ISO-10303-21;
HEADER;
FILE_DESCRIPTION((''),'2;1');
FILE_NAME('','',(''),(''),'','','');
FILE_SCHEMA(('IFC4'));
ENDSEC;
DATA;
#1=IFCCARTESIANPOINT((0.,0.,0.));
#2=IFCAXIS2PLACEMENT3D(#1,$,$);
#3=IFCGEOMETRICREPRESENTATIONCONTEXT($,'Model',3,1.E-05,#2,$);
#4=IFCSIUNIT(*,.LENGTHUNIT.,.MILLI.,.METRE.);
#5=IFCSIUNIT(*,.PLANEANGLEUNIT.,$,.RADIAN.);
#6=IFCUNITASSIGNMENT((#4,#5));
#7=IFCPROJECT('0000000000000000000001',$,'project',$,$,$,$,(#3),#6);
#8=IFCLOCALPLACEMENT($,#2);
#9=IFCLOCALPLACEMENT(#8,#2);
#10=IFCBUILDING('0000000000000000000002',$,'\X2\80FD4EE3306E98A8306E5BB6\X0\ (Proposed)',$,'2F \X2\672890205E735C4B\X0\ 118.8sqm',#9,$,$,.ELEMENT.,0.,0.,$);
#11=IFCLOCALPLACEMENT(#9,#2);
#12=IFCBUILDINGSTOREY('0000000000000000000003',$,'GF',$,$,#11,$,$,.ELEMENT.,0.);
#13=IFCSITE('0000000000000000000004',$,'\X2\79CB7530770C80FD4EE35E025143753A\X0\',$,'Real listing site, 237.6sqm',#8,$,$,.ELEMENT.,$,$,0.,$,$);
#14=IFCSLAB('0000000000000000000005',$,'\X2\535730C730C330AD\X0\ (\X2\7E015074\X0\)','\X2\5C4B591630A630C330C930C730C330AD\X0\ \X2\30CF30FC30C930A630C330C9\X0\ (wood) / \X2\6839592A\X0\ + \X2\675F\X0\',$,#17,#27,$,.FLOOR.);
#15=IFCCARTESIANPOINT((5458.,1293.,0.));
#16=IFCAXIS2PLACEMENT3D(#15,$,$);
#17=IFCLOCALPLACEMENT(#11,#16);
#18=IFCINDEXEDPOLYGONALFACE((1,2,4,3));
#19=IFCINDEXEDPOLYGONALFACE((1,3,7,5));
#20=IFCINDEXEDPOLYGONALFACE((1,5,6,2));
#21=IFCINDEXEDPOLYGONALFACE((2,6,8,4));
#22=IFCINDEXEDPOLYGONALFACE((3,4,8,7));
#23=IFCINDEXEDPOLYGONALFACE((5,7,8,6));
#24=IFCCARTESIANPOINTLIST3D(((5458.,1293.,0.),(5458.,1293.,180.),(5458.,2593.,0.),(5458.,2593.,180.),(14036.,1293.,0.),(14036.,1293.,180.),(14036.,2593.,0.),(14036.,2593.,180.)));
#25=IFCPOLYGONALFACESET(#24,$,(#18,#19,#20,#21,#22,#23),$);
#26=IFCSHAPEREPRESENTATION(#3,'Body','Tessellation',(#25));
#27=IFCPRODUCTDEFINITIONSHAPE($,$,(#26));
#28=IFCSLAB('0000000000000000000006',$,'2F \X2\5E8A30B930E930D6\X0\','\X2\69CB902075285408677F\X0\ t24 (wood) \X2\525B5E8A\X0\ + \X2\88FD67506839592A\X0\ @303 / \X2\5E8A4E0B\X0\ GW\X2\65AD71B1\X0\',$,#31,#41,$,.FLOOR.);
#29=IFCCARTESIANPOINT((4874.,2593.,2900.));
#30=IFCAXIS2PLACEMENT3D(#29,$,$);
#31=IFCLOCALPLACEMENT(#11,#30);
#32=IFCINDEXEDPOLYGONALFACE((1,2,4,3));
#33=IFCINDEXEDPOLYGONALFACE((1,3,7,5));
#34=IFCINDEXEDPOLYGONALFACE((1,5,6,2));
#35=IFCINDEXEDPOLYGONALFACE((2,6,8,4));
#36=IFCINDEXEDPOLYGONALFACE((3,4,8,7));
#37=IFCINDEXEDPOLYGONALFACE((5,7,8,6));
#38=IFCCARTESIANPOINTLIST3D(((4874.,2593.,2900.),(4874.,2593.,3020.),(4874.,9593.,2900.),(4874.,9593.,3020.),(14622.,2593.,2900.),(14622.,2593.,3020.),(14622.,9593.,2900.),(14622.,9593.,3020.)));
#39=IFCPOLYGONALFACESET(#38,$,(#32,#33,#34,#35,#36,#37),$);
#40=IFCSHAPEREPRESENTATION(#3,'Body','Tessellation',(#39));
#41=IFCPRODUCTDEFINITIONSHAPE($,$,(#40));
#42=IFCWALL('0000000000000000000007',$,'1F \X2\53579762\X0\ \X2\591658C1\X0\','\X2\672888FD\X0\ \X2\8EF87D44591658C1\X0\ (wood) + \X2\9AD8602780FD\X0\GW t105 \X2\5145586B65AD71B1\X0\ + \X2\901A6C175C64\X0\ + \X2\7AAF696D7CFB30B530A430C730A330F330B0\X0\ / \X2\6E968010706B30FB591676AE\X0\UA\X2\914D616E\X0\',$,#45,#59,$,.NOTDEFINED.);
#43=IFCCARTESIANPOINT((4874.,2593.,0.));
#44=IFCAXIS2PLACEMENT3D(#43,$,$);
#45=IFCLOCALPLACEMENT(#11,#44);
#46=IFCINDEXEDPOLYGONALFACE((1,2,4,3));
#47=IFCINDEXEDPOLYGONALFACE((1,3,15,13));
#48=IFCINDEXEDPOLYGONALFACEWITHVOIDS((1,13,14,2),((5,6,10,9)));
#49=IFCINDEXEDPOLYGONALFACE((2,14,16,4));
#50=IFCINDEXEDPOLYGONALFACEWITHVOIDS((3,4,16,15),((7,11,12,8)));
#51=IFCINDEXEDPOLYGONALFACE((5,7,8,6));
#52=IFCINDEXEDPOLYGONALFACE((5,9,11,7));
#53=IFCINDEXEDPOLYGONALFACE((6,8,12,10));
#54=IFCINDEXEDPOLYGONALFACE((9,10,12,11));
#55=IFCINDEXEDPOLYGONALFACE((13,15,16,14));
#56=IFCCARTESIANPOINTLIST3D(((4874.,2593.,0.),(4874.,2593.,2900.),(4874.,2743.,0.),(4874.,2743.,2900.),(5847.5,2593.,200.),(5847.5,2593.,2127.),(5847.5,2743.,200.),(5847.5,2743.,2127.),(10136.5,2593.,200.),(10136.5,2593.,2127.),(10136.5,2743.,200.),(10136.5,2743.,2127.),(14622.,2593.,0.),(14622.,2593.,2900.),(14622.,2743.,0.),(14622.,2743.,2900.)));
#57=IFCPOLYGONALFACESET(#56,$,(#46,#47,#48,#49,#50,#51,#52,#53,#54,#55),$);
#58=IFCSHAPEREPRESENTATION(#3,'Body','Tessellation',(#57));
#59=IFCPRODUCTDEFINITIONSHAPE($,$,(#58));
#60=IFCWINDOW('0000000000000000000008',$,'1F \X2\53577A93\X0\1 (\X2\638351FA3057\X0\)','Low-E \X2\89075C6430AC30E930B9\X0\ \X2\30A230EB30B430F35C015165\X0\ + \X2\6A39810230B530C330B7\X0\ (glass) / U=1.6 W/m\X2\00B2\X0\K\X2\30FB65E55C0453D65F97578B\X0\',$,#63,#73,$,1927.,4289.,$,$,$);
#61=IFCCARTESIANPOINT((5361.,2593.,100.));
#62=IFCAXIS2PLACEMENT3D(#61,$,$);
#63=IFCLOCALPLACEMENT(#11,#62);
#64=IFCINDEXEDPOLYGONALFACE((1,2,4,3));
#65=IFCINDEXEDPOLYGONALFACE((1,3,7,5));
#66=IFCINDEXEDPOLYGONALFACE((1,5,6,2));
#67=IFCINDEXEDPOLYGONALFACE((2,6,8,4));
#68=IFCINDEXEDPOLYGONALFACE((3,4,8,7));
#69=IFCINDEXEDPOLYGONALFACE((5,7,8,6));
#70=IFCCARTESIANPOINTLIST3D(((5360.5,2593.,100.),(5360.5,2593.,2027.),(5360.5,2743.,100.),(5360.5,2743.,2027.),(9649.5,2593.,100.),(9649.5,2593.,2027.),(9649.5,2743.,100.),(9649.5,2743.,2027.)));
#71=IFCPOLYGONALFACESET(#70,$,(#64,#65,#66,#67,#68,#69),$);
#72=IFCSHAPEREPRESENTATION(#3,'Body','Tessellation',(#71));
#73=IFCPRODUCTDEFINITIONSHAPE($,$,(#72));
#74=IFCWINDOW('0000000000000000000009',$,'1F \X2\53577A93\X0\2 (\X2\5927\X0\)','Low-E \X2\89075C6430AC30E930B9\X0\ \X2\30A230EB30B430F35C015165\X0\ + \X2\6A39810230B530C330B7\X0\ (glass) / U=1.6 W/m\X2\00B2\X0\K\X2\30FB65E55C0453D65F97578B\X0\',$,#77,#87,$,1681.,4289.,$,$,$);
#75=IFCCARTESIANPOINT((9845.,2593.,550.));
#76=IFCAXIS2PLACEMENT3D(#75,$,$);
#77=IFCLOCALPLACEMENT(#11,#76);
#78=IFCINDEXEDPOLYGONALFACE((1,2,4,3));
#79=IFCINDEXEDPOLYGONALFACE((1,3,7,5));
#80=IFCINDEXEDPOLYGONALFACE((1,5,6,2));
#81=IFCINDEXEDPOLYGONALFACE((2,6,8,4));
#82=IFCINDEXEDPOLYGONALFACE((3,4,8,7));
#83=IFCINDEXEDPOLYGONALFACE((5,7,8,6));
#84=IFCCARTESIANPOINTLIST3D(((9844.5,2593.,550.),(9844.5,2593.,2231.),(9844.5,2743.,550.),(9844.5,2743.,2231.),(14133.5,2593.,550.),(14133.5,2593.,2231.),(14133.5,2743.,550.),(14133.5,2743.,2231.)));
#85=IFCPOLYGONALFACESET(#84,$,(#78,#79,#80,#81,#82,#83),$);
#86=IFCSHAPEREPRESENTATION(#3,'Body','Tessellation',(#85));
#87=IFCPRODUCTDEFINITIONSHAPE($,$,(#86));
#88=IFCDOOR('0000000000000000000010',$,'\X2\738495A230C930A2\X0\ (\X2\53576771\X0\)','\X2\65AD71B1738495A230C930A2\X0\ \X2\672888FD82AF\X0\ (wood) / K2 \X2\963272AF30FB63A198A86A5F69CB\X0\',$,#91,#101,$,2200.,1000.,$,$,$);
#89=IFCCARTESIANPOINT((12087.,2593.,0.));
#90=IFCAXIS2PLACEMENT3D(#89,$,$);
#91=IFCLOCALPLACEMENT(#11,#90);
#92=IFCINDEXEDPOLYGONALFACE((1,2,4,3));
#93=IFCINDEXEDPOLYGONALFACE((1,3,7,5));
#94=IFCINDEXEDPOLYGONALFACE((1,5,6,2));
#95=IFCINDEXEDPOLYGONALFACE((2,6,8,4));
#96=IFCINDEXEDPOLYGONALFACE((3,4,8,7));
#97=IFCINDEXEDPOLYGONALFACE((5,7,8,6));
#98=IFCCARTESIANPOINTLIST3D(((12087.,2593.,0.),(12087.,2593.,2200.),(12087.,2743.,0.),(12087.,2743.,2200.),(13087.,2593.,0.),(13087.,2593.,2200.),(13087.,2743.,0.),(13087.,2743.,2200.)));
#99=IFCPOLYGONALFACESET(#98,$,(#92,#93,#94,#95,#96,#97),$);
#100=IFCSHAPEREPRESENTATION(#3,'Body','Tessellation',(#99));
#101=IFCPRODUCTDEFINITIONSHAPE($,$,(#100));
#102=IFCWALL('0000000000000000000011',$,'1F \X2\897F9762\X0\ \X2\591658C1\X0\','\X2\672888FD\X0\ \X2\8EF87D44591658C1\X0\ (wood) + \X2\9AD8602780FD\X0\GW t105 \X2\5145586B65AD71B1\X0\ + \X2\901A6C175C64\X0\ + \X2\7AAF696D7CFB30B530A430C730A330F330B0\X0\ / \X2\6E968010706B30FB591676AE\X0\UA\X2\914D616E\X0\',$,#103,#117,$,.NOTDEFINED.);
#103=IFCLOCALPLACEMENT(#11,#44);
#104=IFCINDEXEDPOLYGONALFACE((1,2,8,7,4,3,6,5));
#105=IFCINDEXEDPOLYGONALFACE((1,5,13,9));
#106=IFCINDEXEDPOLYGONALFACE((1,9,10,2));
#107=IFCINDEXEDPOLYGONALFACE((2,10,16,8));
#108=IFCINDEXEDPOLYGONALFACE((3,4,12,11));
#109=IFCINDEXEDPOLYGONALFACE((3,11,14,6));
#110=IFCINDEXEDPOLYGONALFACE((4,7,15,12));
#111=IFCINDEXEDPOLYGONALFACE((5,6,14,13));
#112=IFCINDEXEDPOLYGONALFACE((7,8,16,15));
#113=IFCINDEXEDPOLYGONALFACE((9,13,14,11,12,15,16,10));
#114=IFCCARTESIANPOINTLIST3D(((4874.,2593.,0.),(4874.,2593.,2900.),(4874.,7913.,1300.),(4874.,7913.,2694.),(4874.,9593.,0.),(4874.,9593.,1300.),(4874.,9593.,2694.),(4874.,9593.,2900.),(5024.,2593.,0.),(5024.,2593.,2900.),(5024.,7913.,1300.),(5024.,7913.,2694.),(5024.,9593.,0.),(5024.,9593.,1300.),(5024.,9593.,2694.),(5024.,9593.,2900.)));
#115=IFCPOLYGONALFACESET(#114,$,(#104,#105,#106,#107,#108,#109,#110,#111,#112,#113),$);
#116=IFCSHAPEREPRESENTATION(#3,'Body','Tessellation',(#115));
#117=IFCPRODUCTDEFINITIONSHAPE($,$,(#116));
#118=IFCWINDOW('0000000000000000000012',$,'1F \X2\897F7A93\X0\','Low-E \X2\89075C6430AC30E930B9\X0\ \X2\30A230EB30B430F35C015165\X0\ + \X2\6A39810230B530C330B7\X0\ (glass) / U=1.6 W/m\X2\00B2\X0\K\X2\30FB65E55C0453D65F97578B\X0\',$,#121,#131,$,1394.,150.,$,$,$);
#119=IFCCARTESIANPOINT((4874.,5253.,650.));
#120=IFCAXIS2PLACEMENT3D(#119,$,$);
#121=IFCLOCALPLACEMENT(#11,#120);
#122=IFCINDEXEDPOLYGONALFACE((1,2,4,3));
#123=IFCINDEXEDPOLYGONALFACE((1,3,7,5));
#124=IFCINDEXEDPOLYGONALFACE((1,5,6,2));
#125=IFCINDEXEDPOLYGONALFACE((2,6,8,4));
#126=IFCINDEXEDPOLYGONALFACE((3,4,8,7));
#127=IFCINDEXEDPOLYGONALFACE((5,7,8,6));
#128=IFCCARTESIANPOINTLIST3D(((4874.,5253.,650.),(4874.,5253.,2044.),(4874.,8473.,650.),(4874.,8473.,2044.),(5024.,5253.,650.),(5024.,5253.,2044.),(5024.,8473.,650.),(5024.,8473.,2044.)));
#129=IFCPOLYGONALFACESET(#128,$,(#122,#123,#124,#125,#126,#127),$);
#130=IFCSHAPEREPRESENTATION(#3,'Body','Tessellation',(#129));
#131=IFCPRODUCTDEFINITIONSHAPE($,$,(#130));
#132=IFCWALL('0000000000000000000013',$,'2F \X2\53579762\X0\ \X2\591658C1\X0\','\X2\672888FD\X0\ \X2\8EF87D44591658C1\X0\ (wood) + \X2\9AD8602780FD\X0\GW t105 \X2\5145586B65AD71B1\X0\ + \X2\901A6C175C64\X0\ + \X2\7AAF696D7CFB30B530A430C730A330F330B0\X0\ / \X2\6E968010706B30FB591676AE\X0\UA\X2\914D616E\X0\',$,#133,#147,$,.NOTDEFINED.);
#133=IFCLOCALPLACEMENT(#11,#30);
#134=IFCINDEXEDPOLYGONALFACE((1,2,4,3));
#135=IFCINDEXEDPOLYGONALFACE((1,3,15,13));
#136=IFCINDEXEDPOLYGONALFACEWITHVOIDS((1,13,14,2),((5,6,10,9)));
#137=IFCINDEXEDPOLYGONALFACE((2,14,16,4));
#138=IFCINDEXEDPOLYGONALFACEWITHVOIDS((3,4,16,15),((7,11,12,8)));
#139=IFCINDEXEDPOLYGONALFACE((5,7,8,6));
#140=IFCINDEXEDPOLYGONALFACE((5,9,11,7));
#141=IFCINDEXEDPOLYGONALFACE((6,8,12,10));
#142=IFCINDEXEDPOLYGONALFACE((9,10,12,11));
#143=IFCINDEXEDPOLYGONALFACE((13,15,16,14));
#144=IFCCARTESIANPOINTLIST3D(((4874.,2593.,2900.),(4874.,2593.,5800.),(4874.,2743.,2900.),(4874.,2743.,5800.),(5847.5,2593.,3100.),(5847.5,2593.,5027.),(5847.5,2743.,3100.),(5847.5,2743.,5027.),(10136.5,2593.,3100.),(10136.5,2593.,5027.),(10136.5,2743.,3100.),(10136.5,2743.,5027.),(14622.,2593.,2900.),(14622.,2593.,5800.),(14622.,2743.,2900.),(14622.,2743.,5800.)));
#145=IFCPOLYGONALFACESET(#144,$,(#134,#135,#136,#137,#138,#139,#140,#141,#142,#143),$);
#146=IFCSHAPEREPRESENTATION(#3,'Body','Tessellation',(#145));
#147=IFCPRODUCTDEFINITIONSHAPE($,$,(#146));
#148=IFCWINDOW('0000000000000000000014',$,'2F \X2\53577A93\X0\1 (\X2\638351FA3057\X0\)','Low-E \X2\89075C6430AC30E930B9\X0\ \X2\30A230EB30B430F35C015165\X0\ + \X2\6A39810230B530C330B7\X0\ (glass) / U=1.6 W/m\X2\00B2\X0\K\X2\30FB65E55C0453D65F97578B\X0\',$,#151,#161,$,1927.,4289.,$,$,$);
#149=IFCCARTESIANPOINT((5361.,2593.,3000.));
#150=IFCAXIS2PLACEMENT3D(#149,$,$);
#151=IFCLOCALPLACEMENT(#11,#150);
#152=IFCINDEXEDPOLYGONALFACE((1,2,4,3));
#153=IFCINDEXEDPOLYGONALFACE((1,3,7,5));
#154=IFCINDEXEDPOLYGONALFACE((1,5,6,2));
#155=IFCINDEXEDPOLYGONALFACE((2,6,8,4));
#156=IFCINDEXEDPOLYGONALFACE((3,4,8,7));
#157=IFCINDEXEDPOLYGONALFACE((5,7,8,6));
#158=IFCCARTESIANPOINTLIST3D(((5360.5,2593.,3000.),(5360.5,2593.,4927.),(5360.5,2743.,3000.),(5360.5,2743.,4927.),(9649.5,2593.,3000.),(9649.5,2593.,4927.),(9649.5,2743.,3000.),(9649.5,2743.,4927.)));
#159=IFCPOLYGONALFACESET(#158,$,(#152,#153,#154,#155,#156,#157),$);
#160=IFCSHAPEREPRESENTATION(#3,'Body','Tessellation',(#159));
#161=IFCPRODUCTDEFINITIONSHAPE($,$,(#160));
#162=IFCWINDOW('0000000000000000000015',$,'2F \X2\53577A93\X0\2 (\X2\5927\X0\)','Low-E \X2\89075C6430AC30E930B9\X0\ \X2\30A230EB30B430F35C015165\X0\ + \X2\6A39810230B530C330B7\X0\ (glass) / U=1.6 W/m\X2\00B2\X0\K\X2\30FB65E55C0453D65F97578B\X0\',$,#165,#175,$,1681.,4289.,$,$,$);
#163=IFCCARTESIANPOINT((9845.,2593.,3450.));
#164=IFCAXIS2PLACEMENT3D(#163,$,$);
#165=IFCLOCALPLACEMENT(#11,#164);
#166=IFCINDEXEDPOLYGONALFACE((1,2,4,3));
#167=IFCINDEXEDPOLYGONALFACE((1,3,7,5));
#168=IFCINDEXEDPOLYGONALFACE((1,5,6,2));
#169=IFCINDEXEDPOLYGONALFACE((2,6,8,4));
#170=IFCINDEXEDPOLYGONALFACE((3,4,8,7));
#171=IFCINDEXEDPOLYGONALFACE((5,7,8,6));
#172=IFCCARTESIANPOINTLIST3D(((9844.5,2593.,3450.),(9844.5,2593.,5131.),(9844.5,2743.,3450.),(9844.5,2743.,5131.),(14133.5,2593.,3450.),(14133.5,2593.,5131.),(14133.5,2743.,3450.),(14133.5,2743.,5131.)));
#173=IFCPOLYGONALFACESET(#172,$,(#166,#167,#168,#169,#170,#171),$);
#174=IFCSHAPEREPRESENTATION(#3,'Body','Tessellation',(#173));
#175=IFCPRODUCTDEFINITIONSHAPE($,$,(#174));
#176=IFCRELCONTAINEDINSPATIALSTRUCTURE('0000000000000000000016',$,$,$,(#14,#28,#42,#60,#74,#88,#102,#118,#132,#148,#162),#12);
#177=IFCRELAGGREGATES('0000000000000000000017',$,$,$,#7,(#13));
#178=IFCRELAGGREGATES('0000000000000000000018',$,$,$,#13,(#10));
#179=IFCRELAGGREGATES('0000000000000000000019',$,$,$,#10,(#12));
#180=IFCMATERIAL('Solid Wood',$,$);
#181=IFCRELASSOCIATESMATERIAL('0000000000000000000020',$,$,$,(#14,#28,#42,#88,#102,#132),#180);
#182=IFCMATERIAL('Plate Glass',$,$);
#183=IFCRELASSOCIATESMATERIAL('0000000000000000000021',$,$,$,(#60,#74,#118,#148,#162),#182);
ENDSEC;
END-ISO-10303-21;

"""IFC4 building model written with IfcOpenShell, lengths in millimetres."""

from ifc_helpers import new_model, si_unit, frame, frame_2d, origin, place, context, project, spatial, rectangle, extrude, material, element, fill, save


model = new_model("IFC4")

# Units and contexts
model_context = context("Model", 3, precision=1e-05, world=origin())
ifc_project = project(units=[si_unit("LENGTHUNIT", "METRE", prefix="MILLI"), si_unit("PLANEANGLEUNIT", "RADIAN")], contexts=[model_context])

# Site, building, storey
site_placement = place(None, origin())
site = spatial("IfcSite", under=ifc_project, at=site_placement, Name="秋田県能代市元町", ObjectType="Real listing site, 237.6sqm", CompositionType="ELEMENT", RefElevation=0.0)
building_placement = place(site_placement, origin())
building = spatial("IfcBuilding", under=site, at=building_placement, Name="能代の風の家 (Proposed)", ObjectType="2F 木造平屋 118.8sqm", CompositionType="ELEMENT", ElevationOfRefHeight=0.0, ElevationOfTerrain=0.0)
storey_placement = place(building_placement, origin())
storey = spatial("IfcBuildingStorey", under=building, at=storey_placement, Name="GF", CompositionType="ELEMENT", Elevation=0.0)

# Slabs
ifc_material_1 = material(Name="Solid Wood")
slab_1_placement = place(storey_placement, frame((5458.0, 1293.0, 0.0)))
element("IfcSlab", 1, at=slab_1_placement, inside=storey, material=ifc_material_1, Name="南デッキ (縁側)", Description="屋外ウッドデッキ ハードウッド (wood) / 根太 + 束", PredefinedType="FLOOR", context=model_context, shape_type="SweptSolid", body=[
    extrude(rectangle(XDim=8578.0, YDim=1300.0, at=frame_2d((4289.0, 650.0))), frame((5458.0, 1293.0, 0.0)), (0.0, 0.0, 1.0), 180.0),
])
slab_2_placement = place(storey_placement, frame((4874.0, 2593.0, 2900.0)))
element("IfcSlab", 2, at=slab_2_placement, inside=storey, material=ifc_material_1, Name="2F 床スラブ", Description="構造用合板 t24 (wood) 剛床 + 製材根太 @303 / 床下 GW断熱", PredefinedType="FLOOR", context=model_context, shape_type="SweptSolid", body=[
    extrude(rectangle(XDim=9748.0, YDim=7000.0, at=frame_2d((4874.0, 3500.0))), frame((4874.0, 2593.0, 2900.0)), (0.0, 0.0, 1.0), 120.0),
])

# Wall, openings, windows, door
wall_1_placement = place(storey_placement, frame((4874.0, 2593.0, 0.0)))
wall_1 = element("IfcWall", 3, at=wall_1_placement, inside=storey, material=ifc_material_1, Name="1F 南面 外壁", Description="木製 軸組外壁 (wood) + 高性能GW t105 充填断熱 + 通気層 + 窯業系サイディング / 準耐火・外皮UA配慮", PredefinedType="NOTDEFINED", context=model_context, shape_type="SweptSolid", body=[
    extrude(rectangle(XDim=9748.0, YDim=150.0, at=frame_2d((4874.0, 75.0))), frame((4874.0, 2593.0, 0.0)), (0.0, 0.0, 1.0), 2900.0),
])
opening_1_placement = place(storey_placement, frame((5361.0, 2593.0, 100.0)))
opening_1 = element("IfcOpeningElement", 4, at=opening_1_placement, cuts=wall_1, PredefinedType="NOTDEFINED", context=model_context, shape_type="SweptSolid", body=[
    extrude(rectangle(XDim=4289.0, YDim=150.0, at=frame_2d((2144.0, 75.0))), frame((5361.0, 2593.0, 100.0)), (0.0, 0.0, 1.0), 1927.0),
])
opening_2_placement = place(storey_placement, frame((9845.0, 2593.0, 550.0)))
opening_2 = element("IfcOpeningElement", 5, at=opening_2_placement, cuts=wall_1, PredefinedType="NOTDEFINED", context=model_context, shape_type="SweptSolid", body=[
    extrude(rectangle(XDim=4289.0, YDim=150.0, at=frame_2d((2144.0, 75.0))), frame((9845.0, 2593.0, 550.0)), (0.0, 0.0, 1.0), 1681.0),
])
opening_3_placement = place(storey_placement, frame((12087.0, 2593.0, 0.0)))
opening_3 = element("IfcOpeningElement", 6, at=opening_3_placement, cuts=wall_1, PredefinedType="NOTDEFINED", context=model_context, shape_type="SweptSolid", body=[
    extrude(rectangle(XDim=1000.0, YDim=150.0, at=frame_2d((500.0, 75.0))), frame((12087.0, 2593.0, 0.0)), (0.0, 0.0, 1.0), 2200.0),
])
ifc_material_2 = material(Name="Plate Glass")
window_1_placement = place(storey_placement, frame((5361.0, 2593.0, 100.0)))
window_1 = element("IfcWindow", 7, at=window_1_placement, inside=storey, material=ifc_material_2, Name="1F 南窓1 (掃出し)", Description="Low-E 複層ガラス アルゴン封入 + 樹脂サッシ (glass) / U=1.6 W/m²K・日射取得型", OverallHeight=1927.0, OverallWidth=4289.0, context=model_context, shape_type="SweptSolid", body=[
    extrude(rectangle(XDim=4289.0, YDim=150.0, at=frame_2d((2144.0, 75.0))), frame((5361.0, 2593.0, 100.0)), (0.0, 0.0, 1.0), 1927.0),
])
fill(opening_1, window_1)
window_2_placement = place(storey_placement, frame((9845.0, 2593.0, 550.0)))
window_2 = element("IfcWindow", 8, at=window_2_placement, inside=storey, material=ifc_material_2, Name="1F 南窓2 (大)", Description="Low-E 複層ガラス アルゴン封入 + 樹脂サッシ (glass) / U=1.6 W/m²K・日射取得型", OverallHeight=1681.0, OverallWidth=4289.0, context=model_context, shape_type="SweptSolid", body=[
    extrude(rectangle(XDim=4289.0, YDim=150.0, at=frame_2d((2144.0, 75.0))), frame((9845.0, 2593.0, 550.0)), (0.0, 0.0, 1.0), 1681.0),
])
fill(opening_2, window_2)
door_placement = place(storey_placement, frame((12087.0, 2593.0, 0.0)))
door = element("IfcDoor", 9, at=door_placement, inside=storey, material=ifc_material_1, Name="玄関ドア (南東)", Description="断熱玄関ドア 木製芯 (wood) / K2 防犯・採風機構", OverallHeight=2200.0, OverallWidth=1000.0, context=model_context, shape_type="SweptSolid", body=[
    extrude(rectangle(XDim=1000.0, YDim=150.0, at=frame_2d((500.0, 75.0))), frame((12087.0, 2593.0, 0.0)), (0.0, 0.0, 1.0), 2200.0),
])
fill(opening_3, door)

# Wall, opening, window
wall_2_placement = place(storey_placement, frame((4874.0, 2593.0, 0.0)))
wall_2 = element("IfcWall", 10, at=wall_2_placement, inside=storey, material=ifc_material_1, Name="1F 西面 外壁", Description="木製 軸組外壁 (wood) + 高性能GW t105 充填断熱 + 通気層 + 窯業系サイディング / 準耐火・外皮UA配慮", PredefinedType="NOTDEFINED", context=model_context, shape_type="SweptSolid", body=[
    extrude(rectangle(XDim=150.0, YDim=7000.0, at=frame_2d((75.0, 3500.0))), frame((4874.0, 2593.0, 0.0)), (0.0, 0.0, 1.0), 2900.0),
])
opening_4_placement = place(storey_placement, frame((4874.0, 5253.0, 650.0)))
opening_4 = element("IfcOpeningElement", 11, at=opening_4_placement, cuts=wall_2, PredefinedType="NOTDEFINED", context=model_context, shape_type="SweptSolid", body=[
    extrude(rectangle(XDim=150.0, YDim=3220.0, at=frame_2d((75.0, 1610.0))), frame((4874.0, 5253.0, 650.0)), (0.0, 0.0, 1.0), 1394.0),
])
window_3_placement = place(storey_placement, frame((4874.0, 5253.0, 650.0)))
window_3 = element("IfcWindow", 12, at=window_3_placement, inside=storey, material=ifc_material_2, Name="1F 西窓", Description="Low-E 複層ガラス アルゴン封入 + 樹脂サッシ (glass) / U=1.6 W/m²K・日射取得型", OverallHeight=1394.0, OverallWidth=150.0, context=model_context, shape_type="SweptSolid", body=[
    extrude(rectangle(XDim=150.0, YDim=3220.0, at=frame_2d((75.0, 1610.0))), frame((4874.0, 5253.0, 650.0)), (0.0, 0.0, 1.0), 1394.0),
])
fill(opening_4, window_3)

# Wall, openings, windows
wall_3_placement = place(storey_placement, frame((4874.0, 2593.0, 2900.0)))
wall_3 = element("IfcWall", 13, at=wall_3_placement, inside=storey, material=ifc_material_1, Name="2F 南面 外壁", Description="木製 軸組外壁 (wood) + 高性能GW t105 充填断熱 + 通気層 + 窯業系サイディング / 準耐火・外皮UA配慮", PredefinedType="NOTDEFINED", context=model_context, shape_type="SweptSolid", body=[
    extrude(rectangle(XDim=9748.0, YDim=150.0, at=frame_2d((4874.0, 75.0))), frame((4874.0, 2593.0, 2900.0)), (0.0, 0.0, 1.0), 2900.0),
])
opening_5_placement = place(storey_placement, frame((5361.0, 2593.0, 3000.0)))
opening_5 = element("IfcOpeningElement", 14, at=opening_5_placement, cuts=wall_3, PredefinedType="NOTDEFINED", context=model_context, shape_type="SweptSolid", body=[
    extrude(rectangle(XDim=4289.0, YDim=150.0, at=frame_2d((2144.0, 75.0))), frame((5361.0, 2593.0, 3000.0)), (0.0, 0.0, 1.0), 1927.0),
])
opening_6_placement = place(storey_placement, frame((9845.0, 2593.0, 3450.0)))
opening_6 = element("IfcOpeningElement", 15, at=opening_6_placement, cuts=wall_3, PredefinedType="NOTDEFINED", context=model_context, shape_type="SweptSolid", body=[
    extrude(rectangle(XDim=4289.0, YDim=150.0, at=frame_2d((2144.0, 75.0))), frame((9845.0, 2593.0, 3450.0)), (0.0, 0.0, 1.0), 1681.0),
])
window_4_placement = place(storey_placement, frame((5361.0, 2593.0, 3000.0)))
window_4 = element("IfcWindow", 16, at=window_4_placement, inside=storey, material=ifc_material_2, Name="2F 南窓1 (掃出し)", Description="Low-E 複層ガラス アルゴン封入 + 樹脂サッシ (glass) / U=1.6 W/m²K・日射取得型", OverallHeight=1927.0, OverallWidth=4289.0, context=model_context, shape_type="SweptSolid", body=[
    extrude(rectangle(XDim=4289.0, YDim=150.0, at=frame_2d((2144.0, 75.0))), frame((5361.0, 2593.0, 3000.0)), (0.0, 0.0, 1.0), 1927.0),
])
fill(opening_5, window_4)
window_5_placement = place(storey_placement, frame((9845.0, 2593.0, 3450.0)))
window_5 = element("IfcWindow", 17, at=window_5_placement, inside=storey, material=ifc_material_2, Name="2F 南窓2 (大)", Description="Low-E 複層ガラス アルゴン封入 + 樹脂サッシ (glass) / U=1.6 W/m²K・日射取得型", OverallHeight=1681.0, OverallWidth=4289.0, context=model_context, shape_type="SweptSolid", body=[
    extrude(rectangle(XDim=4289.0, YDim=150.0, at=frame_2d((2144.0, 75.0))), frame((9845.0, 2593.0, 3450.0)), (0.0, 0.0, 1.0), 1681.0),
])
fill(opening_6, window_5)

save(model, "model.ifc")
